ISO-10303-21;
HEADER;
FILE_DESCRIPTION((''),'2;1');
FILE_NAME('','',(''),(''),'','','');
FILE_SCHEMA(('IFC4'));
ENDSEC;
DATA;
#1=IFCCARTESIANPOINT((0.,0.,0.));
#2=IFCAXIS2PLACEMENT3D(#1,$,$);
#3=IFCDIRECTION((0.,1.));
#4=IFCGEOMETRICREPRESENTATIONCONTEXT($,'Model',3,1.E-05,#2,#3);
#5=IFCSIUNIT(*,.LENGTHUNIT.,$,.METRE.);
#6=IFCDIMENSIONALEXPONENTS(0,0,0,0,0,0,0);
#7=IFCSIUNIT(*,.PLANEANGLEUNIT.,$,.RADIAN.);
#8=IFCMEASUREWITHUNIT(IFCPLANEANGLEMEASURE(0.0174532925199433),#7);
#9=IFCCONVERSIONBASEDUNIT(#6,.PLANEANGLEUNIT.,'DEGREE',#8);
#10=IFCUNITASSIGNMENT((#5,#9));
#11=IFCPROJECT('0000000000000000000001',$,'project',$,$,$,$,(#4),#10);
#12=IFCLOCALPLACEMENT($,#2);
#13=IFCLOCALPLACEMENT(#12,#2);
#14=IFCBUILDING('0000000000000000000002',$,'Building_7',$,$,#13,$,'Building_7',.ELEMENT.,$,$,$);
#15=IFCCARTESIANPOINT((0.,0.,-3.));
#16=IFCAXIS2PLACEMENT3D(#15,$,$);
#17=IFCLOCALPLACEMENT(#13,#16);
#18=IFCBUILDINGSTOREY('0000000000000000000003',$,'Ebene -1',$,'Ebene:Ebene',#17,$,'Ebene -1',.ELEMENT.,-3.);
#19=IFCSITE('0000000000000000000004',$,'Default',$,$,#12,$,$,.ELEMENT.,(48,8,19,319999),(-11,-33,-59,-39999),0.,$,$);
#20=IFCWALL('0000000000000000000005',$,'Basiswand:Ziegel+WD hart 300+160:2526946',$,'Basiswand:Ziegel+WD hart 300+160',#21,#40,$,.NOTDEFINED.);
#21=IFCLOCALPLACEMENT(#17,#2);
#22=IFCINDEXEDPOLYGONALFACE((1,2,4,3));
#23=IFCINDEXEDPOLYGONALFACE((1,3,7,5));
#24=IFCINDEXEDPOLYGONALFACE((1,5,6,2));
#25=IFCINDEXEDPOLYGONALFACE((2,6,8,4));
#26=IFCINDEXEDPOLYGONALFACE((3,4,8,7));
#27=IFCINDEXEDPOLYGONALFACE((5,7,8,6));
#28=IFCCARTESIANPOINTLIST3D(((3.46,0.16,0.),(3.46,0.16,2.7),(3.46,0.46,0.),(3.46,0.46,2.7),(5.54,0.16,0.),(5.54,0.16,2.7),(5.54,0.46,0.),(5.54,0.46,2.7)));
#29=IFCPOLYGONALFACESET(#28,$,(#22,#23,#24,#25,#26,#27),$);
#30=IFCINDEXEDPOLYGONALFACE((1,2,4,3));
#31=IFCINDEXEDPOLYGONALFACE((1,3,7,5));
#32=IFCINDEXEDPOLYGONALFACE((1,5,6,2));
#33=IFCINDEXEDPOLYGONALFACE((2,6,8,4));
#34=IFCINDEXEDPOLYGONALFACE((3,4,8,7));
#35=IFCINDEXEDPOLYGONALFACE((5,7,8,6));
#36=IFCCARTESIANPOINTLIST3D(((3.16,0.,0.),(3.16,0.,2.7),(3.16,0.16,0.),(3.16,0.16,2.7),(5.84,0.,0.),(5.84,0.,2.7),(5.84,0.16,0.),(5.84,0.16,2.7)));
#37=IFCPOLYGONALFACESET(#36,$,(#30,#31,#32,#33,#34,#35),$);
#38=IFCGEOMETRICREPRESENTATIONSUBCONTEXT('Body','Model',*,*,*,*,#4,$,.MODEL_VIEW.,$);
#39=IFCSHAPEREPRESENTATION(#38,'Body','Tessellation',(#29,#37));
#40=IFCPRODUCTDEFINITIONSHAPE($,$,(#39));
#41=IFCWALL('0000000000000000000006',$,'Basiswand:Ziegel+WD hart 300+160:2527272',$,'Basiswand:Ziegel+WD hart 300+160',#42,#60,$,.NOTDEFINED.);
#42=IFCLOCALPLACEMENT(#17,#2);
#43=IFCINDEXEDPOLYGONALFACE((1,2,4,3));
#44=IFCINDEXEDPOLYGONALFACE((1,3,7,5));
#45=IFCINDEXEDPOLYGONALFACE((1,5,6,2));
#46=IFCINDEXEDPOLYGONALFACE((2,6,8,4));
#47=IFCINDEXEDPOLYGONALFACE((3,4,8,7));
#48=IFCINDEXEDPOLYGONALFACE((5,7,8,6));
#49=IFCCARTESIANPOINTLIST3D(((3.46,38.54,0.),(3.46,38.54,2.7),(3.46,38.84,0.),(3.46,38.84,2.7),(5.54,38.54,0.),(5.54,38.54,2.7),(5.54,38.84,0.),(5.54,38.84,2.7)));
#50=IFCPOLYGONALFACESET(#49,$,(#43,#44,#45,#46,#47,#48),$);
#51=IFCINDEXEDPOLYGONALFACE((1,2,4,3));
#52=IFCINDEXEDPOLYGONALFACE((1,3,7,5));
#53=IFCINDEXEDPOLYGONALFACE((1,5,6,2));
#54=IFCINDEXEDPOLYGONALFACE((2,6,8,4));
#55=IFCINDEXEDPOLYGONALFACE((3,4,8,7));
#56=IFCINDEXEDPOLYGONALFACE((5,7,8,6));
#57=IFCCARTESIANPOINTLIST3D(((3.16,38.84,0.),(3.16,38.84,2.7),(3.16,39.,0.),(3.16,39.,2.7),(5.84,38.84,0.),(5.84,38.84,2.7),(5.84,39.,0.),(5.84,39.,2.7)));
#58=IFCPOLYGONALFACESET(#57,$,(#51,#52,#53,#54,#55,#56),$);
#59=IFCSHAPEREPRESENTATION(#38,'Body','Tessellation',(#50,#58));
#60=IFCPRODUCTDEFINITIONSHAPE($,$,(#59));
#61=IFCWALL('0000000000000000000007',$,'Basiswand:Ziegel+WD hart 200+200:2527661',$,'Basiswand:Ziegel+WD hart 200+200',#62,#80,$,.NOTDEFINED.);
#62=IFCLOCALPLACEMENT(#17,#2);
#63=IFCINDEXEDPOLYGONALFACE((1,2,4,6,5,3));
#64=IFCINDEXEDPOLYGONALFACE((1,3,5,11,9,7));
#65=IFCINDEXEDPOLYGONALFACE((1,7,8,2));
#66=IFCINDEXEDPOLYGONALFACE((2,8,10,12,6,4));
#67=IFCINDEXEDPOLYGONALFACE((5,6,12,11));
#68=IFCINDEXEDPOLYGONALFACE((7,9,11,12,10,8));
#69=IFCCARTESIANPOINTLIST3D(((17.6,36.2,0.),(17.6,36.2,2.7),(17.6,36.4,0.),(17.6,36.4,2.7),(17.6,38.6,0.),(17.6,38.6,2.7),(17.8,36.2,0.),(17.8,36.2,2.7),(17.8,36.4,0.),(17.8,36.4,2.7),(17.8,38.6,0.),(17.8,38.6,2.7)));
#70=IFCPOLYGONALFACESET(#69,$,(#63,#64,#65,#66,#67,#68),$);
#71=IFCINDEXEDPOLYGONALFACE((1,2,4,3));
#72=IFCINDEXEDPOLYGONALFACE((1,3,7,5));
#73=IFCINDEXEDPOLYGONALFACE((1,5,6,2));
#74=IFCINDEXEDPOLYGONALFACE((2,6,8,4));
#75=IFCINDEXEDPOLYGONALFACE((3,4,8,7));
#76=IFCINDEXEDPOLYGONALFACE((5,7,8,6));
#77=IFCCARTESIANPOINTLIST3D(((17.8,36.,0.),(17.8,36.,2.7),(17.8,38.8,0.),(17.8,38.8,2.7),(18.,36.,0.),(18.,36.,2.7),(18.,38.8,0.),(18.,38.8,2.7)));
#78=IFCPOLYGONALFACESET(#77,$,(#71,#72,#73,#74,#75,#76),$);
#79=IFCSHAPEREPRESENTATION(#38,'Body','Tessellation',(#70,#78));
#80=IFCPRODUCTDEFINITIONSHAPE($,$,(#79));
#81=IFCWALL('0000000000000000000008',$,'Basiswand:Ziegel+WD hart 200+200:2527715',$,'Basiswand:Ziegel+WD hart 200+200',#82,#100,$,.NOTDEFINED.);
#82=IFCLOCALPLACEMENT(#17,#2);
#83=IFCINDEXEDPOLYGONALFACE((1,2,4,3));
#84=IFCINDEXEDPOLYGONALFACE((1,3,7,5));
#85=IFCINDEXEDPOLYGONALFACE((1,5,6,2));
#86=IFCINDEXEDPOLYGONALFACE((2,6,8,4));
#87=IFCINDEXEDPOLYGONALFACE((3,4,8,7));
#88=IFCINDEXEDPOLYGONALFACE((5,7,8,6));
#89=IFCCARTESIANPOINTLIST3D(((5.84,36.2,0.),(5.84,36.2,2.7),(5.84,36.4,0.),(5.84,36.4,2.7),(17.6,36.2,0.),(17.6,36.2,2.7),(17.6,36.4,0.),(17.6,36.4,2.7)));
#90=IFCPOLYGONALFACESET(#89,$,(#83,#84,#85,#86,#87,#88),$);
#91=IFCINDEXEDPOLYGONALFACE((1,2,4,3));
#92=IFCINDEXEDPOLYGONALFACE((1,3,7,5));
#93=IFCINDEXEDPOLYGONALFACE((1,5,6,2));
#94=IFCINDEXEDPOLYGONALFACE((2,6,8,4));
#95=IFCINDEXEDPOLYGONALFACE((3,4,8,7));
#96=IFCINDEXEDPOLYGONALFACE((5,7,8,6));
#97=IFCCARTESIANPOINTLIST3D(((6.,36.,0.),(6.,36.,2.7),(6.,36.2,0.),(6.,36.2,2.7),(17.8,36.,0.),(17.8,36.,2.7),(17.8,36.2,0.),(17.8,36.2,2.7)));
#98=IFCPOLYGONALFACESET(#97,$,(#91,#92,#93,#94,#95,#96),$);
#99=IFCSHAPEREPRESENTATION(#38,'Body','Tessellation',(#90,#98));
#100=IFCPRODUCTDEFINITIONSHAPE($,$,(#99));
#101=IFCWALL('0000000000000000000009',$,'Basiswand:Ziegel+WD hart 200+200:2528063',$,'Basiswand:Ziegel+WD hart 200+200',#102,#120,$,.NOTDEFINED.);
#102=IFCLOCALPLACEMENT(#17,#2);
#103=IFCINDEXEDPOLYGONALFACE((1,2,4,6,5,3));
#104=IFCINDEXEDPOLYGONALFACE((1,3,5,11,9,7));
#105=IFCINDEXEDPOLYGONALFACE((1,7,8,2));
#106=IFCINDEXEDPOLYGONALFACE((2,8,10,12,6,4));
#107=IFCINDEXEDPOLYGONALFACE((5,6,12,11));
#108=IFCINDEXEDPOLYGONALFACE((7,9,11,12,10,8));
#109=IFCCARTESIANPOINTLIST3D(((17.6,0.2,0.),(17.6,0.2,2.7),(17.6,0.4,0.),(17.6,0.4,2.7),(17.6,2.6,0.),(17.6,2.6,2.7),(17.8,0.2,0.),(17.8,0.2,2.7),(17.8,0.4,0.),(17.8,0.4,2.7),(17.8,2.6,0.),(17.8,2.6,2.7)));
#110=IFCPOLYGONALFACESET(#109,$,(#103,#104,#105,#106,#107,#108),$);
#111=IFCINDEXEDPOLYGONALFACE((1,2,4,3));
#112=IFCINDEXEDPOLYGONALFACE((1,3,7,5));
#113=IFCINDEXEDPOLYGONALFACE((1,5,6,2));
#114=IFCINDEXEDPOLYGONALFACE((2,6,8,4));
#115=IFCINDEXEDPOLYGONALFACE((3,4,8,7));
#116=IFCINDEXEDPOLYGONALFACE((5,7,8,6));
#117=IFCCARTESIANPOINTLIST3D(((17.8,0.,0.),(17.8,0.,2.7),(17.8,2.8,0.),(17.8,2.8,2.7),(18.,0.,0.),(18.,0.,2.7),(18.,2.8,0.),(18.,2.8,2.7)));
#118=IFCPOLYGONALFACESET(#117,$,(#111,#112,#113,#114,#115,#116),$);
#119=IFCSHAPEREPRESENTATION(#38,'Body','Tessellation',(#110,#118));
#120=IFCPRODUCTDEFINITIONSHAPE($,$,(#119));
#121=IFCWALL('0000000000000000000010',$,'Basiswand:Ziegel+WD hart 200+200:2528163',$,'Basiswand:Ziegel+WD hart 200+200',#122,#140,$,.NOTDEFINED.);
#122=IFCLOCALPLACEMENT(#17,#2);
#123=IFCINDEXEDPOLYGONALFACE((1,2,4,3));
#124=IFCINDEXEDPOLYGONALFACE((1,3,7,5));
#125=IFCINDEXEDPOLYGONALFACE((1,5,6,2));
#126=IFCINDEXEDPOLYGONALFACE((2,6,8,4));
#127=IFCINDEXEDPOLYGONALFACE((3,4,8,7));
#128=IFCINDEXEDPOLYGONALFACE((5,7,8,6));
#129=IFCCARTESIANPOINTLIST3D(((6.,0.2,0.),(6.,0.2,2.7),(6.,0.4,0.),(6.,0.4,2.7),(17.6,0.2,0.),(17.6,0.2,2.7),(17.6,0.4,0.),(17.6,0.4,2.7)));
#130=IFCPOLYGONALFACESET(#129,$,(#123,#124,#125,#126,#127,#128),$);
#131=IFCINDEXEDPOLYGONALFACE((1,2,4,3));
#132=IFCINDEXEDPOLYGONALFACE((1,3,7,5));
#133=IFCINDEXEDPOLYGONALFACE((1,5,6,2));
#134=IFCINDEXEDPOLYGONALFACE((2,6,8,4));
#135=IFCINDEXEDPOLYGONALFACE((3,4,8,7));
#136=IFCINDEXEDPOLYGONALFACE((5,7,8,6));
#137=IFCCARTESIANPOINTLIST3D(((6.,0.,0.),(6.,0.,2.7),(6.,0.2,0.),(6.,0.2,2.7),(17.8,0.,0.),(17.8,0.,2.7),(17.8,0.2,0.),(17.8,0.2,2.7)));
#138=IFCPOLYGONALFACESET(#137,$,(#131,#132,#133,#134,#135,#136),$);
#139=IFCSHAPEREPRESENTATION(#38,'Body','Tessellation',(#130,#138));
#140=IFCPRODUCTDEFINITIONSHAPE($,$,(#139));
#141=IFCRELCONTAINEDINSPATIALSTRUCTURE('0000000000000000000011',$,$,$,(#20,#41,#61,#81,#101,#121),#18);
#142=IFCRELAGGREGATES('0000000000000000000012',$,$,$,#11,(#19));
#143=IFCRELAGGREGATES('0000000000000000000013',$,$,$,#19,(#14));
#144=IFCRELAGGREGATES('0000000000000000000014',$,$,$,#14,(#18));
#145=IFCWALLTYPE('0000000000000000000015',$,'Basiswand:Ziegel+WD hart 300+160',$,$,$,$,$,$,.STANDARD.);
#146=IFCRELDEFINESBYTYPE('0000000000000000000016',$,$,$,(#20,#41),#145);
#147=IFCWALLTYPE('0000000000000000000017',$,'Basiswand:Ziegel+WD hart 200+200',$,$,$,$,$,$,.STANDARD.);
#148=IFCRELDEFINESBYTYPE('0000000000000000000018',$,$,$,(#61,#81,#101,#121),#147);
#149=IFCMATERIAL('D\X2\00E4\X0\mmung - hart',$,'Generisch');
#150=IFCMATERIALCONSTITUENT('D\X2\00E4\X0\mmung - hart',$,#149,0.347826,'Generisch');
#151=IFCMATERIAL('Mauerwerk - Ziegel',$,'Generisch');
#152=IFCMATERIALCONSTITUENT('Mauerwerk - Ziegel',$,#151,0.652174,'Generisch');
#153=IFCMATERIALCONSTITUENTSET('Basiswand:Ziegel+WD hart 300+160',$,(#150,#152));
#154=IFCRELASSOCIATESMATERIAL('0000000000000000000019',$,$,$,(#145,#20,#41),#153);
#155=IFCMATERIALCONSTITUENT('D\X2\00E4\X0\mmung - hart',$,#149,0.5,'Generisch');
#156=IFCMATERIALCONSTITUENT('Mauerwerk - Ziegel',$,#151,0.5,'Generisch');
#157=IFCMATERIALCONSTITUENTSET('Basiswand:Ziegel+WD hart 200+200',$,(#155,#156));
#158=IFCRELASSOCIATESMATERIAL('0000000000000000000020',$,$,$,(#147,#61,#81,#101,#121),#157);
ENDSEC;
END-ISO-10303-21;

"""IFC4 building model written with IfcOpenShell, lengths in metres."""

from ifc_helpers import new_model, entity, si_unit, converted_unit, direction, frame, origin, place, context, subcontext, project, spatial, indexed_curve, outline, extrude, material, constituent, constituent_set, type_object, element, save


model = new_model("IFC4")

# Units and contexts
model_context = context("Model", 3, precision=1e-05, world=origin(), true_north=direction((0.0, 1.0)))
body_context = subcontext(model_context, "Body", "Model", "MODEL_VIEW")
ifc_project = project(units=[si_unit("LENGTHUNIT", "METRE"), converted_unit("PLANEANGLEUNIT", "DEGREE", entity("IfcPlaneAngleMeasure", 0.0174532925199433), si_unit("PLANEANGLEUNIT", "RADIAN"), dimensions=[0, 0, 0, 0, 0, 0, 0])], contexts=[model_context])

# Site, building, storey
site_placement = place(None, origin())
site = spatial("IfcSite", under=ifc_project, at=site_placement, Name="Default", CompositionType="ELEMENT", RefLatitude=(48, 8, 19, 319999), RefLongitude=(-11, -33, -59, -39999), RefElevation=0.0)
building_placement = place(site_placement, origin())
building = spatial("IfcBuilding", under=site, at=building_placement, Name="Building_7", LongName="Building_7", CompositionType="ELEMENT")
storey_placement = place(building_placement, frame((0.0, 0.0, -3.0)))
storey = spatial("IfcBuildingStorey", under=building, at=storey_placement, Name="Ebene -1", ObjectType="Ebene:Ebene", LongName="Ebene -1", CompositionType="ELEMENT", Elevation=-3.0)

# Shared definitions
ifc_material_1 = material(Name="Dämmung - hart", Category="Generisch")
ifc_constituent_1 = constituent(ifc_material_1, Name="Dämmung - hart", Category="Generisch", fraction=0.347826)
ifc_material_2 = material(Name="Mauerwerk - Ziegel", Category="Generisch")
ifc_constituent_2 = constituent(ifc_material_2, Name="Mauerwerk - Ziegel", Category="Generisch", fraction=0.652174)
ifc_constituent_set_1 = constituent_set(constituents=[ifc_constituent_1, ifc_constituent_2], Name="Basiswand:Ziegel+WD hart 300+160")
wall_type_1 = type_object("IfcWallType", Name="Basiswand:Ziegel+WD hart 300+160", PredefinedType="STANDARD", material=ifc_constituent_set_1)

# Walls
wall_1_placement = place(storey_placement, frame((5.54, 0.23, 0.0), z_axis=(0.0, 0.0, 1.0), x_axis=(-1.0, 0.0, 0.0)))
element("IfcWall", 1, at=wall_1_placement, inside=storey, type_object=wall_type_1, material=ifc_constituent_set_1, Name="Basiswand:Ziegel+WD hart 300+160:2526946", ObjectType="Basiswand:Ziegel+WD hart 300+160", PredefinedType="NOTDEFINED", context=body_context, shape_type="SweptSolid", body=[
    extrude(outline(indexed_curve([(-0.15, -1.04), (0.15, -1.04), (0.15, 1.04), (-0.15, 1.04), (-0.15, -1.04)], self_intersect=False)), frame((1.04, -0.08, 0.0), z_axis=(0.0, 0.0, 1.0), x_axis=(0.0, 1.0, 0.0)), (0.0, 0.0, 1.0), 2.7),
    extrude(outline(indexed_curve([(-0.08, -1.34), (0.08, -1.34), (0.08, 1.34), (-0.08, 1.34), (-0.08, -1.34)], self_intersect=False)), frame((1.04, 0.15, 0.0), z_axis=(0.0, 0.0, 1.0), x_axis=(0.0, -1.0, 0.0)), (0.0, 0.0, 1.0), 2.7),
])
wall_2_placement = place(storey_placement, frame((3.46, 38.77, 0.0)))
element("IfcWall", 2, at=wall_2_placement, inside=storey, type_object=wall_type_1, material=ifc_constituent_set_1, Name="Basiswand:Ziegel+WD hart 300+160:2527272", ObjectType="Basiswand:Ziegel+WD hart 300+160", PredefinedType="NOTDEFINED", context=body_context, shape_type="SweptSolid", body=[
    extrude(outline(indexed_curve([(-0.15, -1.04), (0.15, -1.04), (0.15, 1.04), (-0.15, 1.04), (-0.15, -1.04)], self_intersect=False)), frame((1.04, -0.08, 0.0), z_axis=(0.0, 0.0, 1.0), x_axis=(0.0, 1.0, 0.0)), (0.0, 0.0, 1.0), 2.7),
    extrude(outline(indexed_curve([(-0.08, -1.34), (0.08, -1.34), (0.08, 1.34), (-0.08, 1.34), (-0.08, -1.34)], self_intersect=False)), frame((1.04, 0.15, 0.0), z_axis=(0.0, 0.0, 1.0), x_axis=(0.0, -1.0, 0.0)), (0.0, 0.0, 1.0), 2.7),
])
ifc_constituent_3 = constituent(ifc_material_1, Name="Dämmung - hart", Category="Generisch", fraction=0.5)
ifc_constituent_4 = constituent(ifc_material_2, Name="Mauerwerk - Ziegel", Category="Generisch", fraction=0.5)
ifc_constituent_set_2 = constituent_set(constituents=[ifc_constituent_3, ifc_constituent_4], Name="Basiswand:Ziegel+WD hart 200+200")
wall_type_2 = type_object("IfcWallType", Name="Basiswand:Ziegel+WD hart 200+200", PredefinedType="STANDARD", material=ifc_constituent_set_2)
wall_3_placement = place(storey_placement, frame((17.8, 38.6, 0.0), z_axis=(0.0, 0.0, 1.0), x_axis=(0.0, -1.0, 0.0)))
element("IfcWall", 3, at=wall_3_placement, inside=storey, type_object=wall_type_2, material=ifc_constituent_set_2, Name="Basiswand:Ziegel+WD hart 200+200:2527661", ObjectType="Basiswand:Ziegel+WD hart 200+200", PredefinedType="NOTDEFINED", context=body_context, shape_type="SweptSolid", body=[
    extrude(outline(indexed_curve([(-1.35, -1.5333), (1.35, -1.5333), (1.35, 0.6667), (1.35, 0.8667), (-1.35, 0.8667), (-1.35, 0.6667), (-1.35, -1.5333)], self_intersect=False)), frame((1.5333, -0.2, 1.35), z_axis=(0.0, 1.0, 0.0), x_axis=(0.0, 0.0, 1.0)), (0.0, 0.0, 1.0), 0.2),
    extrude(outline(indexed_curve([(-1.35, -1.4), (1.35, -1.4), (1.35, 1.4), (-1.35, 1.4), (-1.35, -1.4)], self_intersect=False)), frame((1.2, 0.0, 1.35), z_axis=(0.0, 1.0, 0.0), x_axis=(0.0, 0.0, 1.0)), (0.0, 0.0, 1.0), 0.2),
])
wall_4_placement = place(storey_placement, frame((17.6, 36.2, 0.0), z_axis=(0.0, 0.0, 1.0), x_axis=(-1.0, 0.0, 0.0)))
element("IfcWall", 4, at=wall_4_placement, inside=storey, type_object=wall_type_2, material=ifc_constituent_set_2, Name="Basiswand:Ziegel+WD hart 200+200:2527715", ObjectType="Basiswand:Ziegel+WD hart 200+200", PredefinedType="NOTDEFINED", context=body_context, shape_type="SweptSolid", body=[
    extrude(outline(indexed_curve([(-0.1, -5.88), (0.1, -5.88), (0.1, 5.88), (-0.1, 5.88), (-0.1, -5.88)], self_intersect=False)), frame((5.88, -0.1, 0.0), z_axis=(0.0, 0.0, 1.0), x_axis=(0.0, 1.0, 0.0)), (0.0, 0.0, 1.0), 2.7),
    extrude(outline(indexed_curve([(-0.1, -5.9), (0.1, -5.9), (0.1, 5.9), (-0.1, 5.9), (-0.1, -5.9)], self_intersect=False)), frame((5.7, 0.1, 0.0), z_axis=(0.0, 0.0, 1.0), x_axis=(0.0, -1.0, 0.0)), (0.0, 0.0, 1.0), 2.7),
])
wall_5_placement = place(storey_placement, frame((17.8, 2.6, 0.0), z_axis=(0.0, 0.0, 1.0), x_axis=(0.0, -1.0, 0.0)))
element("IfcWall", 5, at=wall_5_placement, inside=storey, type_object=wall_type_2, material=ifc_constituent_set_2, Name="Basiswand:Ziegel+WD hart 200+200:2528063", ObjectType="Basiswand:Ziegel+WD hart 200+200", PredefinedType="NOTDEFINED", context=body_context, shape_type="SweptSolid", body=[
    extrude(outline(indexed_curve([(-1.35, -1.5333), (1.35, -1.5333), (1.35, 0.6667), (1.35, 0.8667), (-1.35, 0.8667), (-1.35, 0.6667), (-1.35, -1.5333)], self_intersect=False)), frame((1.5333, -0.2, 1.35), z_axis=(0.0, 1.0, 0.0), x_axis=(0.0, 0.0, 1.0)), (0.0, 0.0, 1.0), 0.2),
    extrude(outline(indexed_curve([(-1.35, -1.4), (1.35, -1.4), (1.35, 1.4), (-1.35, 1.4), (-1.35, -1.4)], self_intersect=False)), frame((1.2, 0.0, 1.35), z_axis=(0.0, 1.0, 0.0), x_axis=(0.0, 0.0, 1.0)), (0.0, 0.0, 1.0), 0.2),
])
wall_6_placement = place(storey_placement, frame((17.6, 0.2, 0.0), z_axis=(0.0, 0.0, 1.0), x_axis=(-1.0, 0.0, 0.0)))
element("IfcWall", 6, at=wall_6_placement, inside=storey, type_object=wall_type_2, material=ifc_constituent_set_2, Name="Basiswand:Ziegel+WD hart 200+200:2528163", ObjectType="Basiswand:Ziegel+WD hart 200+200", PredefinedType="NOTDEFINED", context=body_context, shape_type="SweptSolid", body=[
    extrude(outline(indexed_curve([(-0.1, -5.8), (0.1, -5.8), (0.1, 5.8), (-0.1, 5.8), (-0.1, -5.8)], self_intersect=False)), frame((5.8, -0.1, 0.0), z_axis=(0.0, 0.0, 1.0), x_axis=(0.0, 1.0, 0.0)), (0.0, 0.0, 1.0), 2.7),
    extrude(outline(indexed_curve([(-0.1, -5.9), (0.1, -5.9), (0.1, 5.9), (-0.1, 5.9), (-0.1, -5.9)], self_intersect=False)), frame((5.7, 0.1, 0.0), z_axis=(0.0, 0.0, 1.0), x_axis=(0.0, -1.0, 0.0)), (0.0, 0.0, 1.0), 2.7),
])

save(model, "model.ifc")
